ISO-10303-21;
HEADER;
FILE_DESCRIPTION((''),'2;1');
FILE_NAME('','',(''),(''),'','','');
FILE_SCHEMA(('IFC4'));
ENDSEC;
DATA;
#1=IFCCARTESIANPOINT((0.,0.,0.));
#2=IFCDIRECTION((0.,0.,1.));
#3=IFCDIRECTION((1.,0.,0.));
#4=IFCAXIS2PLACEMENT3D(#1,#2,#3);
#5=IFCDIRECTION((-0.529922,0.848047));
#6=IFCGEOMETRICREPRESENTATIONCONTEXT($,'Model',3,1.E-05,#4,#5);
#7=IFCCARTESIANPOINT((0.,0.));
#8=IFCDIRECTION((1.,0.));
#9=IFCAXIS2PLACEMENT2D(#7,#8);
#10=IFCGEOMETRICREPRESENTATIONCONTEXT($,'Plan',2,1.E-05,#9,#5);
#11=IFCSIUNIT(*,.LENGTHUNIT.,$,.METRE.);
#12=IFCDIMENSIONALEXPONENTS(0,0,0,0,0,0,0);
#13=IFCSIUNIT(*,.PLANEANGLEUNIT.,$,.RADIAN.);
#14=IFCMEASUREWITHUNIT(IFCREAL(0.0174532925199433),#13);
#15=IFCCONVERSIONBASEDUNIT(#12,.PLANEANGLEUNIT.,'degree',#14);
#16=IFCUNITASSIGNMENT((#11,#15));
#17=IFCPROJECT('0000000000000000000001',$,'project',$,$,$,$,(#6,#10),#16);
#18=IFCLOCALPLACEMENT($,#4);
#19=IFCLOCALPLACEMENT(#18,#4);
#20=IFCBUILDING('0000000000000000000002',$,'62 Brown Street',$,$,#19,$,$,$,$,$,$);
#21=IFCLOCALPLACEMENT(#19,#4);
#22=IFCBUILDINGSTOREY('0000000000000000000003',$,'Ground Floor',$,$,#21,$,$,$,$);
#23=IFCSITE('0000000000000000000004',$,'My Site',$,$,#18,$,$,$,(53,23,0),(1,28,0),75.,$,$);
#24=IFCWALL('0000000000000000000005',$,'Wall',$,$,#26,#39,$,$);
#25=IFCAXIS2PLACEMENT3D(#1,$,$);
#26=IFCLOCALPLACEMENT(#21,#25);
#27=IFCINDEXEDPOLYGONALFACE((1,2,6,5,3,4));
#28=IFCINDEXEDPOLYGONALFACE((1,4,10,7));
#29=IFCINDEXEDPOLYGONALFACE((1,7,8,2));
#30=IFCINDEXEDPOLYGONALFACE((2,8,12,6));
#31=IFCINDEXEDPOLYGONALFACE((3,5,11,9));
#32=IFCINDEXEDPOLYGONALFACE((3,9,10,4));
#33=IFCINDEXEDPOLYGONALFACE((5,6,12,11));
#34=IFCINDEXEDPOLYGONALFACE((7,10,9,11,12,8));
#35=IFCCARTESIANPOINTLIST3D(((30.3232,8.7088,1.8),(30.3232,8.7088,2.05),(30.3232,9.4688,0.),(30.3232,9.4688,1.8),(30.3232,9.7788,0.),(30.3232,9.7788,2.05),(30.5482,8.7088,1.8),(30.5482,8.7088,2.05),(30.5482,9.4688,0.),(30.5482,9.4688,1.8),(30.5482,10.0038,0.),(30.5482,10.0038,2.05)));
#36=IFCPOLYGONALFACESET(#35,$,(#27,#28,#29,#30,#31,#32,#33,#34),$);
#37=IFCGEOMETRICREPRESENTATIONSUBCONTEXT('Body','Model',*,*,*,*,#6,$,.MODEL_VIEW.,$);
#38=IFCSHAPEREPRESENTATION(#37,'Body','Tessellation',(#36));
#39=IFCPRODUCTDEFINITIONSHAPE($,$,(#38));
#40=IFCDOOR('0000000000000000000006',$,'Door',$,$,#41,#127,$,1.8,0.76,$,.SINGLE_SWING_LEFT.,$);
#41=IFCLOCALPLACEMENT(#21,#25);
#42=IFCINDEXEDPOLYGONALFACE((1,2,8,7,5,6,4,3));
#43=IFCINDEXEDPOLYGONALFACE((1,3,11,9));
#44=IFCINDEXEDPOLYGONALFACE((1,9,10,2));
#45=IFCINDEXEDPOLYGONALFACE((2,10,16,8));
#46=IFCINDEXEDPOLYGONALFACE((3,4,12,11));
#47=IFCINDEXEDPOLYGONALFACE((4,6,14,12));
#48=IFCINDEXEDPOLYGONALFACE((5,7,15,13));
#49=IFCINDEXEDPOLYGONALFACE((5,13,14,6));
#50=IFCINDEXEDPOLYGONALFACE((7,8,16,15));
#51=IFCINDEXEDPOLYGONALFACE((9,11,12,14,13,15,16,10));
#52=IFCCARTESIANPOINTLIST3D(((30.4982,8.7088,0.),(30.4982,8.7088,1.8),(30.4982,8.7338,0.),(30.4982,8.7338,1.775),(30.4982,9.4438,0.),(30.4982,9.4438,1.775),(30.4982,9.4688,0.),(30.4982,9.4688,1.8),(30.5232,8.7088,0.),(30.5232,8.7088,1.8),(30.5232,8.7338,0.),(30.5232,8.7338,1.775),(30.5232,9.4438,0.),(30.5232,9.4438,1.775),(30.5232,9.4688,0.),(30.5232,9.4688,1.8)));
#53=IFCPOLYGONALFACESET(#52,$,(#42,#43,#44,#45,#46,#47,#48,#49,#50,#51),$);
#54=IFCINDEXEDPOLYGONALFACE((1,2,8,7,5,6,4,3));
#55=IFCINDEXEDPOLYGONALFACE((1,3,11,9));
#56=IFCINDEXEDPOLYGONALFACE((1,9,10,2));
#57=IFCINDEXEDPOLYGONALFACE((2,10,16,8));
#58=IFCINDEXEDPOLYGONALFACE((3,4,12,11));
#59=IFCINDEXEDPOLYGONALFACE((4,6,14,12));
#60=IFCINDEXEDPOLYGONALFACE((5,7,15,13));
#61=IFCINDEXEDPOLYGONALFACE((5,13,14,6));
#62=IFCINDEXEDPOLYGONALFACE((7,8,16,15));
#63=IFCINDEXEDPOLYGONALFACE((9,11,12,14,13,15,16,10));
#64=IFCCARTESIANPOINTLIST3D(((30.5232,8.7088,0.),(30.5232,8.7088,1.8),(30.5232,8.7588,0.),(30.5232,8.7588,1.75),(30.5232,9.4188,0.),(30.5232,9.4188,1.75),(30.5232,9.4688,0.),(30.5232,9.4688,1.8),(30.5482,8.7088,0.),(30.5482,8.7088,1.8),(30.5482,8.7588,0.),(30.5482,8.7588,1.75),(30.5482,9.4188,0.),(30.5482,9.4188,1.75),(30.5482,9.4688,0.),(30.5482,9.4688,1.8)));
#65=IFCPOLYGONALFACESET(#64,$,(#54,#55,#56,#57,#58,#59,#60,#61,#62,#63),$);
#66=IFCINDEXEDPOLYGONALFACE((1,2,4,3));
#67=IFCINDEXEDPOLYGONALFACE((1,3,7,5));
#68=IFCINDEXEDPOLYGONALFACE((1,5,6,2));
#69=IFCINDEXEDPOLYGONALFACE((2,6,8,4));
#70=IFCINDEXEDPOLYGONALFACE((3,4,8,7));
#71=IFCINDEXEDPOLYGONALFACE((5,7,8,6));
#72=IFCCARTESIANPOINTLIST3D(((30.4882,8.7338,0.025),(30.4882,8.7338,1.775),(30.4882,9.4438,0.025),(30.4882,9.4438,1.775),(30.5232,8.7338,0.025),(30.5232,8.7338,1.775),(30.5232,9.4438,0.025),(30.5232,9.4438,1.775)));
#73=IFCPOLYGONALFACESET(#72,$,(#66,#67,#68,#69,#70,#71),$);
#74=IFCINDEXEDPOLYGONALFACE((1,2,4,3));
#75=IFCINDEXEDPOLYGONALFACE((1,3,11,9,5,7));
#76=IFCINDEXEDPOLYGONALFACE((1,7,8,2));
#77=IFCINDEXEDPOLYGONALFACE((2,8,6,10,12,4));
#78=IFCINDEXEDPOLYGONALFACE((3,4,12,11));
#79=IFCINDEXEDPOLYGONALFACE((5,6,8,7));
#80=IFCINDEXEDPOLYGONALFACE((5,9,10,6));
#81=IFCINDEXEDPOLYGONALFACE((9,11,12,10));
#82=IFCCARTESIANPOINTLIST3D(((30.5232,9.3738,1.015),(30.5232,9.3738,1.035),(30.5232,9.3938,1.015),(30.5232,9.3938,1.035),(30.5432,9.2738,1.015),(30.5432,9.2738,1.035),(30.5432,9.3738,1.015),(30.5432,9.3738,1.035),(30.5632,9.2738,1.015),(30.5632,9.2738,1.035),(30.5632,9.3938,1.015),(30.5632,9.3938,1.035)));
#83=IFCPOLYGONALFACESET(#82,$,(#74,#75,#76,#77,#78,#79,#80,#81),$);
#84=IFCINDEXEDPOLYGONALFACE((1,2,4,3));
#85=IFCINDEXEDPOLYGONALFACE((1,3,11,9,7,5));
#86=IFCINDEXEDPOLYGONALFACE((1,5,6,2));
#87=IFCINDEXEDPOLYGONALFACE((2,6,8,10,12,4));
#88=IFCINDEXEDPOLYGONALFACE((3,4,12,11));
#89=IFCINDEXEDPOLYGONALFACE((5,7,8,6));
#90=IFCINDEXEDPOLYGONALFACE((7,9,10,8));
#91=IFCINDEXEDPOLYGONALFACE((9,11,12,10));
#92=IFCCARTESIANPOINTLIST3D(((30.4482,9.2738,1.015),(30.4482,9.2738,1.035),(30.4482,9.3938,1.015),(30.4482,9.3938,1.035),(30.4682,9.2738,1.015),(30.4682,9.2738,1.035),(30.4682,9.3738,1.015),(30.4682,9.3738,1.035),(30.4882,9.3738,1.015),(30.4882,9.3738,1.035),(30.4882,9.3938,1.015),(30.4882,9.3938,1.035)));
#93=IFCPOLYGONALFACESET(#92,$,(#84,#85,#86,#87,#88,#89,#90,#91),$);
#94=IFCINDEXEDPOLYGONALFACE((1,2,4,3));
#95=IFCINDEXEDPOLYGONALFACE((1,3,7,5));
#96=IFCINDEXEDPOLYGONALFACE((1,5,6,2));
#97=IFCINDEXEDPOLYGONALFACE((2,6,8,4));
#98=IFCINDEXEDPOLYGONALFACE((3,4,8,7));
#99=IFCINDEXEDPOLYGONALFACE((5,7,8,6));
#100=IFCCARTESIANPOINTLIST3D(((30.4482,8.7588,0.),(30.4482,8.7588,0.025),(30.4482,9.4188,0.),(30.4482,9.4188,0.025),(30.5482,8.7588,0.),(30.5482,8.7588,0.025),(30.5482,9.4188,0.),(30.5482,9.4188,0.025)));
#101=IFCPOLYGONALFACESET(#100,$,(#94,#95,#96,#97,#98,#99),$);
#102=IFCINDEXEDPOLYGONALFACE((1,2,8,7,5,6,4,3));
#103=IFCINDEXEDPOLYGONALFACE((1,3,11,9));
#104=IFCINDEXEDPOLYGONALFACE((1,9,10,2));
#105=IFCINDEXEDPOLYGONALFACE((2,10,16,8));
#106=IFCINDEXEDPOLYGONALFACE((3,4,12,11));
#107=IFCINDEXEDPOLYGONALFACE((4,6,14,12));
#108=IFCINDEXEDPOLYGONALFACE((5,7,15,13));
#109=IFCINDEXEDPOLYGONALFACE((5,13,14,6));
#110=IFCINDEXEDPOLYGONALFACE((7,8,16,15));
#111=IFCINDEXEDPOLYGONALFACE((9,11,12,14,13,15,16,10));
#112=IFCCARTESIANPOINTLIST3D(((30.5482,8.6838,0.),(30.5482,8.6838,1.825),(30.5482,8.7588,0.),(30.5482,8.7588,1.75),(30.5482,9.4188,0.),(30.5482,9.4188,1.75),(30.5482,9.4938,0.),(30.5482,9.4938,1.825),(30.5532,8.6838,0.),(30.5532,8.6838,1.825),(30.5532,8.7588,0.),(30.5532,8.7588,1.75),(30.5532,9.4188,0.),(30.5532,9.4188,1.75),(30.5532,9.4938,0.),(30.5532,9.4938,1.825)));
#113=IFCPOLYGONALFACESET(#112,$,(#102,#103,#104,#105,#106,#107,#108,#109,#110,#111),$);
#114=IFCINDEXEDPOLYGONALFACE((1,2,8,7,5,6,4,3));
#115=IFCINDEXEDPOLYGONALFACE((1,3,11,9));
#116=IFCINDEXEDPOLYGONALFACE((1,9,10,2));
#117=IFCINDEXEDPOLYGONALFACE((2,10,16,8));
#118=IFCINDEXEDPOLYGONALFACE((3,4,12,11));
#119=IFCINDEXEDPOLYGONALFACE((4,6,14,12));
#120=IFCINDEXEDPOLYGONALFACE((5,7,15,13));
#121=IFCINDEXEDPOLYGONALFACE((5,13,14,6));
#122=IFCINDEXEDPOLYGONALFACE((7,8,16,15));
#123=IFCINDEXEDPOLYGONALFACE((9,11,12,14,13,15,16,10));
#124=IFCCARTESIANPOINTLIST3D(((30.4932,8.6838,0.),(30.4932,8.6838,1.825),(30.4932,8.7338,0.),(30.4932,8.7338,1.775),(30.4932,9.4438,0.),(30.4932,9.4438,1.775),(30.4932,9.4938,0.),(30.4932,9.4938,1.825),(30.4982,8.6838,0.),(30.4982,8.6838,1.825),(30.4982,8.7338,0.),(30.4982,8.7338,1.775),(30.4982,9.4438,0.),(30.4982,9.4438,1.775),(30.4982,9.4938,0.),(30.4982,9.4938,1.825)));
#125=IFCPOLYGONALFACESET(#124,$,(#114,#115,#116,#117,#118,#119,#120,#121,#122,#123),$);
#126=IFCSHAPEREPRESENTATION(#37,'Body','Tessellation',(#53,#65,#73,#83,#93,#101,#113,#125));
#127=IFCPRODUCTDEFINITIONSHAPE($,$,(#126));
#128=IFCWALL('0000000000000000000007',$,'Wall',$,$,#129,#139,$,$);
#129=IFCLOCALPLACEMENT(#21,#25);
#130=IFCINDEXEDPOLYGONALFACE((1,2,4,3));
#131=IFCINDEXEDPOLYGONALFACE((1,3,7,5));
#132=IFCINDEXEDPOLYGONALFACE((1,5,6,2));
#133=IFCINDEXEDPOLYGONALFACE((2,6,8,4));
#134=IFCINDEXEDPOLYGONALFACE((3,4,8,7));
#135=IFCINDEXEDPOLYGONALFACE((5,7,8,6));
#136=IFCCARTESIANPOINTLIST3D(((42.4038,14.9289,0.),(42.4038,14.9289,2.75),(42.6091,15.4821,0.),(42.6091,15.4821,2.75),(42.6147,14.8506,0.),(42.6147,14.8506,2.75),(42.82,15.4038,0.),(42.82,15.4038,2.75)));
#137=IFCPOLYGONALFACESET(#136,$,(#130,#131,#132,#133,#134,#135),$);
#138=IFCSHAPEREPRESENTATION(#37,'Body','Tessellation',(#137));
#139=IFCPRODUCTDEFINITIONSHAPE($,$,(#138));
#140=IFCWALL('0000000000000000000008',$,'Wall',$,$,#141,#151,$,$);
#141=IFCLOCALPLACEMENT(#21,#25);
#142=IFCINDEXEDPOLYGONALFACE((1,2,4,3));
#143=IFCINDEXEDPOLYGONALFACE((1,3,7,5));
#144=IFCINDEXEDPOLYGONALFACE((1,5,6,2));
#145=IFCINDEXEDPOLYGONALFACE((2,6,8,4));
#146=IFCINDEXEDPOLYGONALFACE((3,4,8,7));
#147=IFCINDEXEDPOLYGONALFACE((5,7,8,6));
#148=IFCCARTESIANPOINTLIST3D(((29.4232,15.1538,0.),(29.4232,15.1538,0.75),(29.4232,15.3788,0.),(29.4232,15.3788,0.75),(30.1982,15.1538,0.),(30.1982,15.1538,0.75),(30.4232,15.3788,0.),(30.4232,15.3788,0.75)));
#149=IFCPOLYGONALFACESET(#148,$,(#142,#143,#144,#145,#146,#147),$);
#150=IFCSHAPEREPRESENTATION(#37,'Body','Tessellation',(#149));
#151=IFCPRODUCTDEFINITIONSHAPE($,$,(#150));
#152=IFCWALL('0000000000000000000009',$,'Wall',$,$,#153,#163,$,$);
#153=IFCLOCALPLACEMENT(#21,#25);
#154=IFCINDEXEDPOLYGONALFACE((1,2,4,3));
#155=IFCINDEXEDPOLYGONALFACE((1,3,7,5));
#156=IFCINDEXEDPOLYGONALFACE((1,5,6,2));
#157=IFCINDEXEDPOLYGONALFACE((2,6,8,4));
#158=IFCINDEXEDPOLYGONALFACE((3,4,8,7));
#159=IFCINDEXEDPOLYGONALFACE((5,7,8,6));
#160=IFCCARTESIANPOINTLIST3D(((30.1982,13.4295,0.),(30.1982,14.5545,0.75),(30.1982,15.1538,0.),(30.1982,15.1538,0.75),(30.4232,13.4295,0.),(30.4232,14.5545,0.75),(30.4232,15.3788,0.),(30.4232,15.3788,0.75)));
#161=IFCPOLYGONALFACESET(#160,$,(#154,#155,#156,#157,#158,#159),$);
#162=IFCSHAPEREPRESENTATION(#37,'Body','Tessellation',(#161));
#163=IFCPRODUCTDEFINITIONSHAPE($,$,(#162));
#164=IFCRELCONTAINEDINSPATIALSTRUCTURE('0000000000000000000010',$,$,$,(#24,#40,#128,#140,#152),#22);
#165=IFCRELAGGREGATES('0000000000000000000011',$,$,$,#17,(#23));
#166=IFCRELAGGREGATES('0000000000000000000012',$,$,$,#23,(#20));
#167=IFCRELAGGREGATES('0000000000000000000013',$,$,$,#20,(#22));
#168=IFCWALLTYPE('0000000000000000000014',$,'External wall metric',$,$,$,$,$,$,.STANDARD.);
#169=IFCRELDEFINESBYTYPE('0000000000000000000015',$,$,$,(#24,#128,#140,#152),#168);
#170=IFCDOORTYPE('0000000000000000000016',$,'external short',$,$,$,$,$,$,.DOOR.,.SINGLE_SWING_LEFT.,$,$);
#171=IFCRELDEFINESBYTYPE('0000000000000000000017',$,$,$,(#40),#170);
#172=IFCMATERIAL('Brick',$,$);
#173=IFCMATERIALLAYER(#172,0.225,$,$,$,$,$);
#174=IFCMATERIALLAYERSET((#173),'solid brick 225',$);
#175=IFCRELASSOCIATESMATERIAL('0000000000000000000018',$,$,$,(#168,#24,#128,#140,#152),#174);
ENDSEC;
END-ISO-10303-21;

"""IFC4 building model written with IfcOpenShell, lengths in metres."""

from ifc_helpers import new_model, entity, si_unit, converted_unit, direction, frame, origin_with_axes, origin_2d_with_axis, place, context, subcontext, project, spatial, line, indexed_curve, outline, extrude, clip, halfspace, shape, source, transform, mapped, material, layer, layer_set, layer_usage, type_object, type_shapes, element, fill, save


model = new_model("IFC4")

# Units and contexts
model_context = context("Model", 3, precision=1e-05, world=origin_with_axes(), true_north=direction((-0.529922, 0.848047)))
plan_context = context("Plan", 2, precision=1e-05, world=origin_2d_with_axis(), true_north=direction((-0.529922, 0.848047)))
body_context_1 = subcontext(model_context, "Body", "Model", "MODEL_VIEW")
body_context_2 = subcontext(plan_context, "Body", "Plan", "PLAN_VIEW")
ifc_project = project(units=[si_unit("LENGTHUNIT", "METRE"), converted_unit("PLANEANGLEUNIT", "degree", entity("IfcReal", 0.0174532925199433), si_unit("PLANEANGLEUNIT", "RADIAN"), dimensions=[0, 0, 0, 0, 0, 0, 0])], contexts=[model_context, plan_context])

# Site, building, storey
site_placement = place(None, origin_with_axes())
site = spatial("IfcSite", under=ifc_project, at=site_placement, Name="My Site", RefLatitude=(53, 23, 0), RefLongitude=(1, 28, 0), RefElevation=75.0)
building_placement = place(site_placement, origin_with_axes())
building = spatial("IfcBuilding", under=site, at=building_placement, Name="62 Brown Street")
storey_placement = place(building_placement, origin_with_axes())
storey = spatial("IfcBuildingStorey", under=building, at=storey_placement, Name="Ground Floor")

# Shared definitions
ifc_material_1 = material(Name="Brick")
ifc_layer_1 = layer(ifc_material_1, 0.225)
ifc_layer_set_1 = layer_set([ifc_layer_1], Name="solid brick 225")
wall_type_1 = type_object("IfcWallType", Name="External wall metric", PredefinedType="STANDARD", material=ifc_layer_set_1)

# Wall, opening, door
ifc_layer_usage_1 = layer_usage(ifc_layer_set_1, "AXIS2", "POSITIVE", 0.0)
wall_1_placement = place(storey_placement, frame((30.5482, 8.7088, 0.0), z_axis=(0.0, 0.0, 1.0), x_axis=(0.0, 1.0, 0.0)))
wall_1 = element("IfcWall", 1, at=wall_1_placement, inside=storey, type_object=wall_type_1, material=ifc_layer_usage_1, Name="Wall", context=body_context_1, shape_type="Clipping", body=[
    clip(extrude(outline(indexed_curve([(0.0, 0.0), (0.0, 0.225), (1.295, 0.225), (1.295, 0.0), (0.0, 0.0)], self_intersect=False)), origin_with_axes(), (0.0, 0.0, 1.0), 2.05), halfspace(frame((1.295, 0.0, 0.0), z_axis=(0.450001, 0.450001, 0.0), x_axis=(-0.225, 0.225, 0.0)), False)),
])
shared_shape_1 = source(origin_with_axes(), body_context_1, "Body", "SweptSolid", [
    extrude(outline(indexed_curve([(0.0, 0.0), (0.76, 0.0), (0.76, 1.8), (0.0, 1.8)], segments=[line(1, 2, 3, 4, 1)])), frame((0.0, -0.1, 0.0), z_axis=(0.0, -1.0, 0.0), x_axis=(1.0, 0.0, 0.0)), (0.0, 0.0, -1.0), 0.425),
])
opening_1_placement = place(wall_1_placement, frame((0.0, 0.0, 0.0), z_axis=(0.0, 0.0, 1.0), x_axis=(1.0, 0.0, 0.0)))
opening_1 = element("IfcOpeningElement", 2, at=opening_1_placement, cuts=wall_1, PredefinedType="OPENING", context=body_context_1, shape_type="MappedRepresentation", body=[
    mapped(shared_shape_1, transform((0.0, 0.0, 0.0), x_axis=(1.0, 0.0, 0.0), y_axis=(0.0, 1.0, 0.0), z_axis=(0.0, 0.0, 1.0), scale=1.0)),
])
door_type_1 = type_object("IfcDoorType", Name="external short", OperationType="SINGLE_SWING_LEFT", PredefinedType="DOOR")
shared_shape_2 = source(origin_with_axes(), body_context_1, "Body", "SweptSolid", [
    extrude(outline(indexed_curve([(0.0, 0.0), (0.0, 1.8), (0.76, 1.8), (0.76, 0.0), (0.735, 0.0), (0.735, 1.775), (0.025, 1.775), (0.025, 0.0)], segments=[line(1, 2, 3, 4, 5, 6, 7, 8, 1)])), frame((0.0, 0.025, 0.0), z_axis=(0.0, -1.0, 0.0), x_axis=(1.0, 0.0, 0.0)), (0.0, 0.0, -1.0), 0.025),
    extrude(outline(indexed_curve([(0.0, 0.0), (0.0, 1.8), (0.76, 1.8), (0.76, 0.0), (0.71, 0.0), (0.71, 1.75), (0.05, 1.75), (0.05, 0.0)], segments=[line(1, 2, 3, 4, 5, 6, 7, 8, 1)])), frame((0.0, 0.0, 0.0), z_axis=(0.0, -1.0, 0.0), x_axis=(1.0, 0.0, 0.0)), (0.0, 0.0, -1.0), 0.025),
    extrude(outline(indexed_curve([(0.0, 0.0), (0.71, 0.0), (0.71, 0.035), (0.0, 0.035)], segments=[line(1, 2, 3, 4, 1)])), frame((0.025, 0.025, 0.025), z_axis=(0.0, 0.0, 1.0), x_axis=(1.0, 0.0, 0.0)), (0.0, 0.0, 1.0), 1.75),
    extrude(outline(indexed_curve([(0.0, 0.0), (0.0, -0.04), (-0.12, -0.04), (-0.12, -0.02), (-0.02, -0.02), (-0.02, 0.0)], segments=[line(1, 2, 3, 4, 5, 6, 1)])), frame((0.685, 0.025, 1.015), z_axis=(0.0, 0.0, 1.0), x_axis=(1.0, 0.0, 0.0)), (0.0, 0.0, 1.0), 0.02),
    extrude(outline(indexed_curve([(0.0, 0.0), (0.0, 0.04), (-0.12, 0.04), (-0.12, 0.02), (-0.02, 0.02), (-0.02, 0.0)], segments=[line(1, 2, 3, 4, 5, 6, 1)])), frame((0.685, 0.06, 1.015), z_axis=(0.0, 0.0, 1.0), x_axis=(1.0, 0.0, 0.0)), (0.0, 0.0, 1.0), 0.02),
    extrude(outline(indexed_curve([(0.0, 0.0), (0.66, 0.0), (0.66, 0.1), (0.0, 0.1)], segments=[line(1, 2, 3, 4, 1)])), frame((0.05, 0.0, 0.0), z_axis=(0.0, 0.0, 1.0), x_axis=(1.0, 0.0, 0.0)), (0.0, 0.0, 1.0), 0.025),
    extrude(outline(indexed_curve([(0.0, 0.0), (0.0, 1.825), (0.81, 1.825), (0.81, 0.0), (0.735, 0.0), (0.735, 1.75), (0.075, 1.75), (0.075, 0.0)], segments=[line(1, 2, 3, 4, 5, 6, 7, 8, 1)])), frame((-0.025, -0.005, 0.0), z_axis=(0.0, -1.0, 0.0), x_axis=(1.0, 0.0, 0.0)), (0.0, 0.0, -1.0), 0.005),
    extrude(outline(indexed_curve([(0.0, 0.0), (0.0, 1.825), (0.81, 1.825), (0.81, 0.0), (0.76, 0.0), (0.76, 1.775), (0.05, 1.775), (0.05, 0.0)], segments=[line(1, 2, 3, 4, 5, 6, 7, 8, 1)])), frame((-0.025, 0.05, 0.0), z_axis=(0.0, -1.0, 0.0), x_axis=(1.0, 0.0, 0.0)), (0.0, 0.0, -1.0), 0.005),
])
shared_shape_3 = source(origin_with_axes(), body_context_2, "Body", "Curve2D", [
    entity("IfcIndexedPolyCurve", entity("IfcCartesianPointList2D", [[0.0, 0.0], [0.0, 0.05], [0.025, 0.05], [0.025, 0.025], [0.05, 0.025], [0.05, 0.0]]), [entity("IfcLineIndex", [1, 2, 3, 4, 5, 6, 1])]),
    entity("IfcIndexedPolyCurve", entity("IfcCartesianPointList2D", [[0.76, 0.0], [0.76, 0.05], [0.735, 0.05], [0.735, 0.025], [0.71, 0.025], [0.71, 0.0]]), [entity("IfcLineIndex", [1, 2, 3, 4, 5, 6, 1])]),
    entity("IfcTrimmedCurve", entity("IfcEllipse", entity("IfcAxis2Placement2D", entity("IfcCartesianPoint", [0.06, 0.05]), entity("IfcDirection", [1.0, 0.0])), 0.675, 0.71), [entity("IfcCartesianPoint", [0.735, 0.05])], [entity("IfcCartesianPoint", [0.06, 0.76])], True, "CARTESIAN"),
    entity("IfcIndexedPolyCurve", entity("IfcCartesianPointList2D", [[0.025, 0.05], [0.06, 0.05], [0.06, 0.76], [0.025, 0.76]]), [entity("IfcLineIndex", [1, 2, 3, 4, 1])]),
])
type_shapes(door_type_1, [shared_shape_2, shared_shape_3])
door_1_placement = place(opening_1_placement, frame((0.0, 0.0, 0.0), z_axis=(0.0, 0.0, 1.0), x_axis=(1.0, 0.0, 0.0)))
door_1 = element("IfcDoor", 3, at=door_1_placement, inside=storey, type_object=door_type_1, Name="Door", OperationType="SINGLE_SWING_LEFT", OverallHeight=1.8, OverallWidth=0.76, shapes=[
    shape(body_context_1, "Body", "MappedRepresentation", [mapped(shared_shape_2, transform((0.0, 0.0, 0.0), x_axis=(1.0, 0.0, 0.0), y_axis=(0.0, 1.0, 0.0), z_axis=(0.0, 0.0, 1.0), scale=1.0))]),
    shape(body_context_2, "Body", "MappedRepresentation", [mapped(shared_shape_3, transform((0.0, 0.0, 0.0), x_axis=(1.0, 0.0, 0.0), y_axis=(0.0, 1.0, 0.0), z_axis=(0.0, 0.0, 1.0), scale=1.0))]),
])
fill(opening_1, door_1)

# Walls
ifc_layer_usage_2 = layer_usage(ifc_layer_set_1, "AXIS2", "POSITIVE", 0.0)
wall_2_placement = place(storey_placement, frame((42.6147, 14.8506, 0.0), z_axis=(0.0, 0.0, 1.0), x_axis=(0.347944, 0.937515, 0.0)))
element("IfcWall", 4, at=wall_2_placement, inside=storey, type_object=wall_type_1, material=ifc_layer_usage_2, Name="Wall", context=body_context_1, shape_type="SweptSolid", body=[
    extrude(outline(indexed_curve([(0.0, 0.0), (0.0, 0.225), (0.5901, 0.225), (0.5901, 0.0), (0.0, 0.0)], self_intersect=False)), origin_with_axes(), (0.0, 0.0, 1.0), 2.75),
])
ifc_layer_usage_3 = layer_usage(ifc_layer_set_1, "AXIS2", "POSITIVE", 0.0)
wall_3_placement = place(storey_placement, frame((30.4232, 15.3788, 0.0), z_axis=(0.0, 0.0, 1.0), x_axis=(-1.0, 0.0, 0.0)))
element("IfcWall", 5, at=wall_3_placement, inside=storey, type_object=wall_type_1, material=ifc_layer_usage_3, Name="Wall", context=body_context_1, shape_type="Clipping", body=[
    clip(extrude(outline(indexed_curve([(0.0, 0.0), (0.0, 0.225), (1.0, 0.225), (1.0, 0.0), (0.0, 0.0)], self_intersect=False)), origin_with_axes(), (0.0, 0.0, 1.0), 0.75), halfspace(frame((0.0, 0.0, 0.0), z_axis=(-0.707107, 0.707107, 0.0), x_axis=(0.707107, 0.707107, 0.0)), False)),
])
ifc_layer_usage_4 = layer_usage(ifc_layer_set_1, "AXIS2", "POSITIVE", 0.0)
wall_4_placement = place(storey_placement, frame((30.4232, 13.4295, 0.0), z_axis=(0.0, 0.0, 1.0), x_axis=(0.0, 1.0, 0.0)))
element("IfcWall", 6, at=wall_4_placement, inside=storey, type_object=wall_type_1, material=ifc_layer_usage_4, Name="Wall", context=body_context_1, shape_type="Clipping", body=[
    clip(clip(extrude(outline(indexed_curve([(0.0, 0.0), (0.0, 0.225), (1.9493, 0.225), (1.9493, 0.0), (0.0, 0.0)], self_intersect=False)), origin_with_axes(), (0.0, 0.0, 1.0), 0.75), halfspace(frame((0.416, 0.5, 0.2774), z_axis=(-0.5547, 0.0, 0.83205), x_axis=(0.0, -1.0, 0.0)), False)), halfspace(frame((1.9493, 0.0, 0.0), z_axis=(0.707107, 0.707107, 0.0), x_axis=(0.707107, -0.707107, 0.0)), False)),
])

save(model, "model.ifc")
